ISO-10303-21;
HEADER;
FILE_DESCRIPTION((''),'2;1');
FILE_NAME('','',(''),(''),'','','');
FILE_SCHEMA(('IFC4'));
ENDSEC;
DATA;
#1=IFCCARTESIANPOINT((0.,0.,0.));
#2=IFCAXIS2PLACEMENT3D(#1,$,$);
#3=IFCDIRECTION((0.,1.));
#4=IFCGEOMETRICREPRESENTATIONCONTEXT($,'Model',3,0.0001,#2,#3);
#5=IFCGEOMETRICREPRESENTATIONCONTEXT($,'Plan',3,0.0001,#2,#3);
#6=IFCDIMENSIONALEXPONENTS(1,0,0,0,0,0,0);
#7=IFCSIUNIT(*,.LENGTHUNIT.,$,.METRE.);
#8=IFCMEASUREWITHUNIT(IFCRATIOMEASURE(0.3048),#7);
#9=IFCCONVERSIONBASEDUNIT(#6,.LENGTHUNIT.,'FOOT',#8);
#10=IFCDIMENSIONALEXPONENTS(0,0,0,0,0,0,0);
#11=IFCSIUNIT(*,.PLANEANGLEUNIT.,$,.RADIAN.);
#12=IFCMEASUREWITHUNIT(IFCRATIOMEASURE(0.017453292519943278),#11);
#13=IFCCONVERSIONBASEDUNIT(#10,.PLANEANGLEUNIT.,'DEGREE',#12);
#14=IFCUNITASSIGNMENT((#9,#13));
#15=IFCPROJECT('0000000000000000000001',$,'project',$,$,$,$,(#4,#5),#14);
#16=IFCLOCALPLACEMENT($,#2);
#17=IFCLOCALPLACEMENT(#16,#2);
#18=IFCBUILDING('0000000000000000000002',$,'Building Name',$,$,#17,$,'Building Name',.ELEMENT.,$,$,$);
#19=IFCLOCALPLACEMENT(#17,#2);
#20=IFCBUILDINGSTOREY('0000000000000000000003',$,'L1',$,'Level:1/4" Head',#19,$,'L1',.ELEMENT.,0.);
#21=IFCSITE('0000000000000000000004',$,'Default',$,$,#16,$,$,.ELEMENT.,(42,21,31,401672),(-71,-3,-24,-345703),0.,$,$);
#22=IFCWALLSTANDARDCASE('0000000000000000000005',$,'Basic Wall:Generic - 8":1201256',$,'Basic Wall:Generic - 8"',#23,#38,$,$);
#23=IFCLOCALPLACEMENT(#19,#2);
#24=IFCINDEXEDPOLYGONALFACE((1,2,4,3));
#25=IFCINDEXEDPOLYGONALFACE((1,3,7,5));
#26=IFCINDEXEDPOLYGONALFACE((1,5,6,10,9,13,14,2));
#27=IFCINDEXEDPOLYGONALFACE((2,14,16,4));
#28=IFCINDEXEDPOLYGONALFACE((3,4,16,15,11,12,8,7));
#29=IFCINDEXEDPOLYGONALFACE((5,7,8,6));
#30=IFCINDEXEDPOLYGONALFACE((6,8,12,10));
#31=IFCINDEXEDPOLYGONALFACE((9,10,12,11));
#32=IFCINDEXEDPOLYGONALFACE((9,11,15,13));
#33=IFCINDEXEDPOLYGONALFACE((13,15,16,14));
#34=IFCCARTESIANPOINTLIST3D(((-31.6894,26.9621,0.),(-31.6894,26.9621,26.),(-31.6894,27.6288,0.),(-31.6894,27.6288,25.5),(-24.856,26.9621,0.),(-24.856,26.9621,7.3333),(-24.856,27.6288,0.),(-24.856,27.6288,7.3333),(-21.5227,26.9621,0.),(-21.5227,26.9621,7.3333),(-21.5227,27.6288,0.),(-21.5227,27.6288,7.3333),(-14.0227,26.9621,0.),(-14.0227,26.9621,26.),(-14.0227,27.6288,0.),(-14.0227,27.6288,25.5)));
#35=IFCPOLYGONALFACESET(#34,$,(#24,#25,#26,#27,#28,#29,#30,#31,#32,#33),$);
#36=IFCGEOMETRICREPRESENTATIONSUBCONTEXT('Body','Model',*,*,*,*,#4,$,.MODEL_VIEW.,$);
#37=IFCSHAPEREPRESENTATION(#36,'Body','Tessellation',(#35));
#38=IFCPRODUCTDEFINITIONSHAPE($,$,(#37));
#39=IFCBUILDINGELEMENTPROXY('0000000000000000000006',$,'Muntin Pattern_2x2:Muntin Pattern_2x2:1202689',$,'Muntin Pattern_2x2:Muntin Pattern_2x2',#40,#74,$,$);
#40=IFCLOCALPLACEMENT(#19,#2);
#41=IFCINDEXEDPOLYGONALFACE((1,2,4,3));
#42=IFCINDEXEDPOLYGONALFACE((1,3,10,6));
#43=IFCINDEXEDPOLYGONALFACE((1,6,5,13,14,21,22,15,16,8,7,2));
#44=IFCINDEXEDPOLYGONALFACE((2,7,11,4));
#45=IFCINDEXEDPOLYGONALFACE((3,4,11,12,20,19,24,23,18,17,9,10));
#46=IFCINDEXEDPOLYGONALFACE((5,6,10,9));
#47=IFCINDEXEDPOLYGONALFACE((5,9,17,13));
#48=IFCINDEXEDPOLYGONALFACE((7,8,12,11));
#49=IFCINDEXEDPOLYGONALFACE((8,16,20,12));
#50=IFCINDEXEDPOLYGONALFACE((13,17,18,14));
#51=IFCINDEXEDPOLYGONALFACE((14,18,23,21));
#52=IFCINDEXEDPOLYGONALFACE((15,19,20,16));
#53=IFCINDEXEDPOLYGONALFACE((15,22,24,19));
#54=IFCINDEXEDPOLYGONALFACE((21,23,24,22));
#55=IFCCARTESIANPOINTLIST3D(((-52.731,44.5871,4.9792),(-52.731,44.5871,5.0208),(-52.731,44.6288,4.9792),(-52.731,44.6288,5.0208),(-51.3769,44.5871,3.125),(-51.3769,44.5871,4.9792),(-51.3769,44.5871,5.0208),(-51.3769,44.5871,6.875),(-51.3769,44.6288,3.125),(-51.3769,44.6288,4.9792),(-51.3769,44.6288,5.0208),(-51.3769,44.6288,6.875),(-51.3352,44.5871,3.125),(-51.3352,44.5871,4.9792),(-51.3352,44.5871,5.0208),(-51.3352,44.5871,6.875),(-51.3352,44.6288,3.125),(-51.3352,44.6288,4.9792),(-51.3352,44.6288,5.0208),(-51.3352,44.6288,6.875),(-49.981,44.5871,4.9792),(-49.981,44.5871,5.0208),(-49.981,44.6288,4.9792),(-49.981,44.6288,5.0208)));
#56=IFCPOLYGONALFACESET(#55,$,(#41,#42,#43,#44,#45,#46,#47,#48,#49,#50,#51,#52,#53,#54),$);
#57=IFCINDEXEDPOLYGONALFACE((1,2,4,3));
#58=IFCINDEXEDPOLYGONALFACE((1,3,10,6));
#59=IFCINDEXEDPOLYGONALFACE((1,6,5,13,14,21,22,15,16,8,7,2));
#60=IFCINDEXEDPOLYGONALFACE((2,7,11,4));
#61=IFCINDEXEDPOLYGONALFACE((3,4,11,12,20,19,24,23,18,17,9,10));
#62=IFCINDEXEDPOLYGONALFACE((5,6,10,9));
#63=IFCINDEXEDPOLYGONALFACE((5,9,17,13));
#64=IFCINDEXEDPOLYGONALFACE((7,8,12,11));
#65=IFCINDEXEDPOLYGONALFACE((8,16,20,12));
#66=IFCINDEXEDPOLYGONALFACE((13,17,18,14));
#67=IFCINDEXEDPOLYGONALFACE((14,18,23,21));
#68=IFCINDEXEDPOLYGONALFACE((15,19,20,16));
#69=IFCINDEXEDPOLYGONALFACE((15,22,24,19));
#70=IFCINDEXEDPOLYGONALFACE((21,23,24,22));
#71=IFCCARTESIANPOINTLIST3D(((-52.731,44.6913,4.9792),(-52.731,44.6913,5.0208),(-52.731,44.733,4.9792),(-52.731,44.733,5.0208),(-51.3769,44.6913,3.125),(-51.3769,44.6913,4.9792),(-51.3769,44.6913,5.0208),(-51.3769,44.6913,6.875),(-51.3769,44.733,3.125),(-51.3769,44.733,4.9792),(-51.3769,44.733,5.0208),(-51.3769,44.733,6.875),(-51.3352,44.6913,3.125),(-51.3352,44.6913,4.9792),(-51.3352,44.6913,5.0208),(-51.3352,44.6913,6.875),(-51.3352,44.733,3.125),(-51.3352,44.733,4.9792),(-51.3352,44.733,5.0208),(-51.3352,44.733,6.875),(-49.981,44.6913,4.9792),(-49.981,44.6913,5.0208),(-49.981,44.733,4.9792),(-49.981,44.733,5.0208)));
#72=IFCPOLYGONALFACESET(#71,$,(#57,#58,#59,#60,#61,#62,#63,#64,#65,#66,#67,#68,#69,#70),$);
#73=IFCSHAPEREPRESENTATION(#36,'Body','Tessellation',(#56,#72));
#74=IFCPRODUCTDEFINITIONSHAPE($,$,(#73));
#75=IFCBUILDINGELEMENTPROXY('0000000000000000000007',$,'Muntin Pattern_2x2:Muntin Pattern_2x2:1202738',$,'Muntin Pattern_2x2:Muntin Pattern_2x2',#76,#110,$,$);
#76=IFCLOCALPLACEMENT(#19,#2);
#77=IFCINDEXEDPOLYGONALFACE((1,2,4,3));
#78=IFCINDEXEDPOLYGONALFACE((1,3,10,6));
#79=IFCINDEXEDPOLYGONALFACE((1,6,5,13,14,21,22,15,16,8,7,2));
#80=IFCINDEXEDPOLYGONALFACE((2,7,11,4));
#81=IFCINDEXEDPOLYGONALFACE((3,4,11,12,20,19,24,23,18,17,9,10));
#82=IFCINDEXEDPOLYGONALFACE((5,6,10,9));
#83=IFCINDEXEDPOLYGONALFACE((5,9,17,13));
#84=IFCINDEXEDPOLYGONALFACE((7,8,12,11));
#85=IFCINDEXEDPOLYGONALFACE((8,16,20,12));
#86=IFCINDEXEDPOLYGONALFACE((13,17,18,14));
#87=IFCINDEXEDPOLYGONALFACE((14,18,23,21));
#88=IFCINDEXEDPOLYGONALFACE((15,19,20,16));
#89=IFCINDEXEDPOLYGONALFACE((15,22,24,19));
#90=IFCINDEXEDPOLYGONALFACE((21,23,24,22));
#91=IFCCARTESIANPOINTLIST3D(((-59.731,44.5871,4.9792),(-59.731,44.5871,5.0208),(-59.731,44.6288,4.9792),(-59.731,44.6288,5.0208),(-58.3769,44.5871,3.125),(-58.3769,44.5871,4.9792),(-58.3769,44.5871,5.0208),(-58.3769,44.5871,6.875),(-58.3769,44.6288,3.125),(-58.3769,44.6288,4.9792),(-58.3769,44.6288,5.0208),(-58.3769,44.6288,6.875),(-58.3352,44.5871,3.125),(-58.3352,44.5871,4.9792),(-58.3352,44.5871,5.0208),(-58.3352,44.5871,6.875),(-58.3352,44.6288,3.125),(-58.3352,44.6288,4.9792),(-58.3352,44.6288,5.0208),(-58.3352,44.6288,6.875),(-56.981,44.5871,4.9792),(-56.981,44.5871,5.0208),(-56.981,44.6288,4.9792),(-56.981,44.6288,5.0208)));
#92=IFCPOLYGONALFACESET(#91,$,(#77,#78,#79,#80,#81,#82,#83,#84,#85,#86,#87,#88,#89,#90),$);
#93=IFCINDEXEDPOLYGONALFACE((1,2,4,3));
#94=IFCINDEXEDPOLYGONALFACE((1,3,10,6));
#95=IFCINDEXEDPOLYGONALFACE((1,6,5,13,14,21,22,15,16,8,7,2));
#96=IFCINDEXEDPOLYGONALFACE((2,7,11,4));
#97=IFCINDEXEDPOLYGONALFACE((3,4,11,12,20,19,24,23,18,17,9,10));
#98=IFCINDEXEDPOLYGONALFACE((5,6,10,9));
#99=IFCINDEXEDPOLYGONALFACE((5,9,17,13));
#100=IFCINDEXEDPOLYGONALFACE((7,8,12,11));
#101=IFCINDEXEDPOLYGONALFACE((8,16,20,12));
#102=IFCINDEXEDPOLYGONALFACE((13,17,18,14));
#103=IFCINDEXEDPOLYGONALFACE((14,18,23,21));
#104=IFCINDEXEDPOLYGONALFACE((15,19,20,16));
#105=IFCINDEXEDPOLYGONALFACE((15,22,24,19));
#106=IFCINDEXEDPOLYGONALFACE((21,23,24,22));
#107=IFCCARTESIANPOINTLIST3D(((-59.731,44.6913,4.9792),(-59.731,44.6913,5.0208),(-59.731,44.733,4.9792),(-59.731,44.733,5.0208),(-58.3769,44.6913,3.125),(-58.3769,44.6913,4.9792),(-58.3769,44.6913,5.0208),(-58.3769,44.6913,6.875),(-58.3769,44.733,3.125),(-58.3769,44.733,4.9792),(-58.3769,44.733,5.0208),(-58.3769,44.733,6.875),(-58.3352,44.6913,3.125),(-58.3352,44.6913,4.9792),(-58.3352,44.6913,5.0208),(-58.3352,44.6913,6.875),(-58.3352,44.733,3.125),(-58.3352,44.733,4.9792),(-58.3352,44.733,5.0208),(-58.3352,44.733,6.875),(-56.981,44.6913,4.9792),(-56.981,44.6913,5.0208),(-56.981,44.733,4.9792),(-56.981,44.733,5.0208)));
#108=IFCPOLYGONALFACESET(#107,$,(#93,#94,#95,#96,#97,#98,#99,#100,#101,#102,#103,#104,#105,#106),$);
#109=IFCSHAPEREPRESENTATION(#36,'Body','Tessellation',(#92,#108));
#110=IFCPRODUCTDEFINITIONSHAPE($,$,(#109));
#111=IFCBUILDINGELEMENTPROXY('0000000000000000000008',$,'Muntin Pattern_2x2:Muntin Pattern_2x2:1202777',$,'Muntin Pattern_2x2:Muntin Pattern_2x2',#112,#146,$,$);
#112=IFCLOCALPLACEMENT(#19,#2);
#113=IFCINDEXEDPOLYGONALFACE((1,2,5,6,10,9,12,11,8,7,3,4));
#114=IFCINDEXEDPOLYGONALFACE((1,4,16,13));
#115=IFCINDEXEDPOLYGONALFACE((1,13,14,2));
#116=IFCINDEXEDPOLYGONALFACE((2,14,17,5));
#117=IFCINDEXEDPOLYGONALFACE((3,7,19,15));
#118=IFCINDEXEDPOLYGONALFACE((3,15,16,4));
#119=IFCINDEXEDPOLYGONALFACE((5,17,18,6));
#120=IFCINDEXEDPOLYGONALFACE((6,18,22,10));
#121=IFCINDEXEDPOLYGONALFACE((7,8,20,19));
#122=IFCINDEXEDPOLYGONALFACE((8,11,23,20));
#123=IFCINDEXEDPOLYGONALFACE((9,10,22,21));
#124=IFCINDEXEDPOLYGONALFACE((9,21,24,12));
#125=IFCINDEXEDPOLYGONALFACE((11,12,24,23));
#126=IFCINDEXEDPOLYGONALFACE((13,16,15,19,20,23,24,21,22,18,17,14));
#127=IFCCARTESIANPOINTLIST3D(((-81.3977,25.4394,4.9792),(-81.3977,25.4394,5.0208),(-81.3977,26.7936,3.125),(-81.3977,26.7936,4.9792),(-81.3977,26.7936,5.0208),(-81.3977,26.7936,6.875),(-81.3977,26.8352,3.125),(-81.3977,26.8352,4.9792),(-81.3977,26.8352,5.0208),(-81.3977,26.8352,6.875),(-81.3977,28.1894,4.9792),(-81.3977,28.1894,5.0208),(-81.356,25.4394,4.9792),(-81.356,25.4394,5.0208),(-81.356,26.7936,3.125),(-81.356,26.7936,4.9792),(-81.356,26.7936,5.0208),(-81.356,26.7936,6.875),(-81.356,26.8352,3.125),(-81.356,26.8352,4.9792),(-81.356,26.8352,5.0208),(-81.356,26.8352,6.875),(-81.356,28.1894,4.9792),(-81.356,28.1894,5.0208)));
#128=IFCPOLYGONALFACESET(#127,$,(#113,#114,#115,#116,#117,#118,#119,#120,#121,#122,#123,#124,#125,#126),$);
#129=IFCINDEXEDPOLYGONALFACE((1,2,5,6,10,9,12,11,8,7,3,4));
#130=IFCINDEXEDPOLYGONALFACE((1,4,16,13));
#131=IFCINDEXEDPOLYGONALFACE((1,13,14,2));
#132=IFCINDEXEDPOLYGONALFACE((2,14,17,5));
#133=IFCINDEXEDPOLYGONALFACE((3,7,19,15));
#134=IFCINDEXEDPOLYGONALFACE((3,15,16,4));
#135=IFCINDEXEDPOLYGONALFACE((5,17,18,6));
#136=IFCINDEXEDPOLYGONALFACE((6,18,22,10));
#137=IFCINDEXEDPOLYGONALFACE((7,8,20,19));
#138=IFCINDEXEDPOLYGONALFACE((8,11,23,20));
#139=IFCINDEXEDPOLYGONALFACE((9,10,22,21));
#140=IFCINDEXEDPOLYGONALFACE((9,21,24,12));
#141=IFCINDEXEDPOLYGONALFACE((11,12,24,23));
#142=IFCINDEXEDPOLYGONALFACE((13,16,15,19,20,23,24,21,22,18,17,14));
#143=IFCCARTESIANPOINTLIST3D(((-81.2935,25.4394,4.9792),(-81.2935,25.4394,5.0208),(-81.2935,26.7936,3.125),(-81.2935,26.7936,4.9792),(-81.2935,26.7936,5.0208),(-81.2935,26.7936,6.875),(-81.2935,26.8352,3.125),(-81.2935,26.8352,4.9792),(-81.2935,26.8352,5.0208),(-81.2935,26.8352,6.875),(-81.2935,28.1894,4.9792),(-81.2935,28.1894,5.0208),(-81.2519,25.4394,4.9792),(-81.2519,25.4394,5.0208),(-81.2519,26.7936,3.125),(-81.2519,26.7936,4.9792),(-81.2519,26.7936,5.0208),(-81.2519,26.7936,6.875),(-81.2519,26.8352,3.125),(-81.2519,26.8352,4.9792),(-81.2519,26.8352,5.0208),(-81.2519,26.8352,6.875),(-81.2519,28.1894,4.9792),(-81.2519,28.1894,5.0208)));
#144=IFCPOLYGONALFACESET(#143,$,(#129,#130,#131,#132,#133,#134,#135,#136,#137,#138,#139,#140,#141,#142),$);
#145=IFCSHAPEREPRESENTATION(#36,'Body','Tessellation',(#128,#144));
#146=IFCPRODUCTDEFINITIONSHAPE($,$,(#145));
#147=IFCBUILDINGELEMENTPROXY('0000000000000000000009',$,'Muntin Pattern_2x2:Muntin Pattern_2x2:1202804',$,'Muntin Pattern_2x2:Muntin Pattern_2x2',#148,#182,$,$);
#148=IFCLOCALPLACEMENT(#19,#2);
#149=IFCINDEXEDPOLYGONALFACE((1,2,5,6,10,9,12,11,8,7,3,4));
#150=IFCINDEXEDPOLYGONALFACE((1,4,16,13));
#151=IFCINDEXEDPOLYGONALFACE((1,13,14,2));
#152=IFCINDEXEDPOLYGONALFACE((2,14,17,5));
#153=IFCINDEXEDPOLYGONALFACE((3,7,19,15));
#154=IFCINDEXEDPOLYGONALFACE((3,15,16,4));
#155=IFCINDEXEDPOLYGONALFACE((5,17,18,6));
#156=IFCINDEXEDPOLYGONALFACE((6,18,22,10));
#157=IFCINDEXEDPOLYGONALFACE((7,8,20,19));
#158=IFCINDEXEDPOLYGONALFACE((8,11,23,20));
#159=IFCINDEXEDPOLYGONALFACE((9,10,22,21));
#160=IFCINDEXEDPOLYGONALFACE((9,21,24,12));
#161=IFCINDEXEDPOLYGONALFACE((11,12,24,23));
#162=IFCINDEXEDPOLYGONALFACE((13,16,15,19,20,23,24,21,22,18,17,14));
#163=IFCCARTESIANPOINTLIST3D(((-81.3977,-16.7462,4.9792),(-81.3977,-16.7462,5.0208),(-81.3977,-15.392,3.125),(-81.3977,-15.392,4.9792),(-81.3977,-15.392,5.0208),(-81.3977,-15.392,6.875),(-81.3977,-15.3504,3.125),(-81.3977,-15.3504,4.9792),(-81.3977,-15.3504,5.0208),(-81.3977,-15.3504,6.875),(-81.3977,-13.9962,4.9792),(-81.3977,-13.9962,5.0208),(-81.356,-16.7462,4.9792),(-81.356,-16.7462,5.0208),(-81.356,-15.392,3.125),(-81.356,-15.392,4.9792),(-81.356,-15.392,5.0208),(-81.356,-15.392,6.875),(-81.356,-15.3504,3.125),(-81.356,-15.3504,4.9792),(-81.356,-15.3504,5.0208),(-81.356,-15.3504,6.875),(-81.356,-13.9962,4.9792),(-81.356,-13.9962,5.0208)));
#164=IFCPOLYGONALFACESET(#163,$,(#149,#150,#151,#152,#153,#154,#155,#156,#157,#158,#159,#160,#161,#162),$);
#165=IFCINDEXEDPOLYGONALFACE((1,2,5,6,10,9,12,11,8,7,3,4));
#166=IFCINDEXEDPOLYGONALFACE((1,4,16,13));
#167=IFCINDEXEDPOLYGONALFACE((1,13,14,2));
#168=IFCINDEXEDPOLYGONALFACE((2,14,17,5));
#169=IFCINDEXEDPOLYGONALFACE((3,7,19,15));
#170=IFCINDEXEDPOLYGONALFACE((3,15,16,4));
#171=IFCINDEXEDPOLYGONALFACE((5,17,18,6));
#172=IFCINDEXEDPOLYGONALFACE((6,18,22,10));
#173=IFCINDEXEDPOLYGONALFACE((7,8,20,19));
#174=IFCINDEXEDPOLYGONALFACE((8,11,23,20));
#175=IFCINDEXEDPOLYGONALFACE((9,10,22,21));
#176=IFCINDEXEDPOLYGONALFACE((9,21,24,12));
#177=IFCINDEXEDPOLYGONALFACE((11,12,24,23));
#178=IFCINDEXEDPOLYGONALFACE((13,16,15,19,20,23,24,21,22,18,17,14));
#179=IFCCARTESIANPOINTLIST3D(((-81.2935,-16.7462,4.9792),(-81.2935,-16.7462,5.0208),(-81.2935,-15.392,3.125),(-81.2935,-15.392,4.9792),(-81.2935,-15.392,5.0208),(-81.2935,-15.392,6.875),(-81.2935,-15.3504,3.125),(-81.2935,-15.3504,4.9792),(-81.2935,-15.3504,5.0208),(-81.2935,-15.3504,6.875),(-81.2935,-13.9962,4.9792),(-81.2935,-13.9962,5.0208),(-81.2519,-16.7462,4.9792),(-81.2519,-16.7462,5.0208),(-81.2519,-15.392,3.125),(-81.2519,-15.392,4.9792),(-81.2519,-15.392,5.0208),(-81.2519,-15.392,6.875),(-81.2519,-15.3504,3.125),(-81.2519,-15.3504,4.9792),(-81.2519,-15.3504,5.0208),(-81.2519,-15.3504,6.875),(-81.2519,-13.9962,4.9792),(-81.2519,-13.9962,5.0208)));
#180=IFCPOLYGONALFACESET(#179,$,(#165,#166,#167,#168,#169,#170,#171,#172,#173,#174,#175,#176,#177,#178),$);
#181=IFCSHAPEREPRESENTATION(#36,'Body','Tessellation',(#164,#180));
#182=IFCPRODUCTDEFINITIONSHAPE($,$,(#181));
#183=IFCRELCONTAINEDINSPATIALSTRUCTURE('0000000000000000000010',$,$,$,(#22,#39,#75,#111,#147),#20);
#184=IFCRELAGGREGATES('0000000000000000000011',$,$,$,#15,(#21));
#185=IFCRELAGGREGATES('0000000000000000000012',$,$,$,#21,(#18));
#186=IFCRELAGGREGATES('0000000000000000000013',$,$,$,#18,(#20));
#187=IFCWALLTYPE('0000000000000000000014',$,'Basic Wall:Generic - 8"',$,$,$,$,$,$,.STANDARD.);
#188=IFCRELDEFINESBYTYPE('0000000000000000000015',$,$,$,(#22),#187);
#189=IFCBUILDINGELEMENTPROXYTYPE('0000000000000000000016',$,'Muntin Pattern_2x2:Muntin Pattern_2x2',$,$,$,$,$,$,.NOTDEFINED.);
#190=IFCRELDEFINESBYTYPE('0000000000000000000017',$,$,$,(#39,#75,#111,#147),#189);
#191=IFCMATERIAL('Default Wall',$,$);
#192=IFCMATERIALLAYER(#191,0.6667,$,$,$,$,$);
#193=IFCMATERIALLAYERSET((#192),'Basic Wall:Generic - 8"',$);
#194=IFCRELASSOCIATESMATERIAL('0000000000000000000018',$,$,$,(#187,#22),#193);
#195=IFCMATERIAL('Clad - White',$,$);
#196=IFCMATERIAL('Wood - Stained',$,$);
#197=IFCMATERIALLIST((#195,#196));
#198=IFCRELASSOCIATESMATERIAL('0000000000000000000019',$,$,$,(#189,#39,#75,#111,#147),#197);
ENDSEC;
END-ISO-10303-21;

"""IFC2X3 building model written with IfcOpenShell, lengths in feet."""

from ifc_helpers import new_model, entity, si_unit, converted_unit, direction, frame, frame_2d, origin, place, context, subcontext, project, spatial, polyline, rectangle, outline, extrude, clip, bounded_halfspace, source, transform, mapped, material, material_list, layer, layer_set, layer_usage, type_object, type_shapes, element, save


model = new_model("IFC2X3")

# Units and contexts
model_context = context("Model", 3, precision=0.0001, world=origin(), true_north=direction((0.0, 1.0)))
plan_context = context("Plan", 3, precision=0.0001, world=origin(), true_north=direction((0.0, 1.0)))
body_context = subcontext(model_context, "Body", "Model", "MODEL_VIEW")
ifc_project = project(units=[converted_unit("LENGTHUNIT", "FOOT", entity("IfcRatioMeasure", 0.3048), si_unit("LENGTHUNIT", "METRE"), dimensions=[1, 0, 0, 0, 0, 0, 0]), converted_unit("PLANEANGLEUNIT", "DEGREE", entity("IfcRatioMeasure", 0.017453292519943278), si_unit("PLANEANGLEUNIT", "RADIAN"), dimensions=[0, 0, 0, 0, 0, 0, 0])], contexts=[model_context, plan_context])

# Site, building, storey
site_placement = place(None, origin())
site = spatial("IfcSite", under=ifc_project, at=site_placement, Name="Default", CompositionType="ELEMENT", RefLatitude=(42, 21, 31, 401672), RefLongitude=(-71, -3, -24, -345703), RefElevation=0.0)
building_placement = place(site_placement, origin())
building = spatial("IfcBuilding", under=site, at=building_placement, Name="Building Name", LongName="Building Name", CompositionType="ELEMENT")
storey_placement = place(building_placement, origin())
storey = spatial("IfcBuildingStorey", under=building, at=storey_placement, Name="L1", ObjectType="Level:1/4\" Head", LongName="L1", CompositionType="ELEMENT", Elevation=0.0)

# Shared definitions
ifc_material_1 = material(Name="Default Wall")
ifc_layer_1 = layer(ifc_material_1, 0.6667)
ifc_layer_set_1 = layer_set([ifc_layer_1], Name="Basic Wall:Generic - 8\"")
ifc_layer_usage_1 = layer_usage(ifc_layer_set_1, "AXIS2", "NEGATIVE", 0.3333)
wall_type_1 = type_object("IfcWallType", Name="Basic Wall:Generic - 8\"", PredefinedType="STANDARD", material=ifc_layer_set_1)

# Wall, opening
wall_1_placement = place(storey_placement, frame((-31.6894, 27.2955, 0.0)))
wall_1 = element("IfcWallStandardCase", 1, at=wall_1_placement, inside=storey, type_object=wall_type_1, material=ifc_layer_usage_1, Name="Basic Wall:Generic - 8\":1201256", ObjectType="Basic Wall:Generic - 8\"", context=body_context, shape_type="Clipping", body=[
    clip(extrude(rectangle(XDim=17.6667, YDim=0.6667, at=frame_2d((8.8333, 0.0), x_axis=(1.0, 0.0))), origin(), (0.0, 0.0, 1.0), 26.0), bounded_halfspace(frame((0.0, -0.3333, 26.0), z_axis=(0.0, 0.6, 0.8), x_axis=(-1.0, 0.0, 0.0)), False, frame((0.0, -0.3333, 26.0)), polyline([(0.0, 0.0), (17.6667, 0.0), (17.6667, 0.6667), (17.0, 0.6667), (0.0, 0.6667), (0.0, 0.0)]))),
])
opening_1_placement = place(wall_1_placement, frame((6.8333, -0.3333, 0.0)))
element("IfcOpeningElement", 2, at=opening_1_placement, cuts=wall_1, ObjectType="Opening", context=body_context, shape_type="SweptSolid", body=[
    extrude(rectangle(XDim=7.3333, YDim=3.3333, at=frame_2d((3.6667, 1.6667), x_axis=(1.0, 0.0))), frame((0.0, 0.0, 0.0), z_axis=(0.0, 1.0, 0.0), x_axis=(0.0, 0.0, 1.0)), (0.0, 0.0, 1.0), 0.6667),
])

# Building element proxies
ifc_material_2 = material(Name="Clad - White")
ifc_material_3 = material(Name="Wood - Stained")
ifc_material_list = material_list([ifc_material_2, ifc_material_3])
building_element_proxy_type_1 = type_object("IfcBuildingElementProxyType", Name="Muntin Pattern_2x2:Muntin Pattern_2x2", PredefinedType="NOTDEFINED", material=ifc_material_list)
shared_shape_1 = source(origin(), body_context, "Body", "SweptSolid", [
    extrude(outline(polyline([(0.0208, -0.0208), (1.875, -0.0208), (1.875, 0.0208), (0.0208, 0.0208), (0.0208, 1.375), (-0.0208, 1.375), (-0.0208, 0.0208), (-1.875, 0.0208), (-1.875, -0.0208), (-0.0208, -0.0208), (-0.0208, -1.375), (0.0208, -1.375), (0.0208, -0.0208)])), frame((0.0, -0.0729, 1.875), z_axis=(0.0, 1.0, 0.0), x_axis=(0.0, 0.0, 1.0)), (0.0, 0.0, 1.0), 0.0417),
    extrude(outline(polyline([(0.0208, -0.0208), (1.875, -0.0208), (1.875, 0.0208), (0.0208, 0.0208), (0.0208, 1.375), (-0.0208, 1.375), (-0.0208, 0.0208), (-1.875, 0.0208), (-1.875, -0.0208), (-0.0208, -0.0208), (-0.0208, -1.375), (0.0208, -1.375), (0.0208, -0.0208)])), frame((0.0, 0.0313, 1.875), z_axis=(0.0, 1.0, 0.0), x_axis=(0.0, 0.0, 1.0)), (0.0, 0.0, 1.0), 0.0417),
])
type_shapes(building_element_proxy_type_1, [shared_shape_1])
for number, where, name in (
    (3, (-51.356, 44.66, 3.125), "Muntin Pattern_2x2:Muntin Pattern_2x2:1202689"),
    (4, (-58.356, 44.66, 3.125), "Muntin Pattern_2x2:Muntin Pattern_2x2:1202738"),
):
    element("IfcBuildingElementProxy", number, at=place(storey_placement, frame(where)), inside=storey, type_object=building_element_proxy_type_1, material=ifc_material_list, Name=name, ObjectType="Muntin Pattern_2x2:Muntin Pattern_2x2", context=body_context, shape_type="MappedRepresentation", body=[
        mapped(shared_shape_1, transform((0.0, 0.0, 0.0), scale=1.0)),
    ])
for number, where, z_axis, x_axis, name in (
    (5, (-81.3248, 26.8144, 3.125), (0.0, 0.0, 1.0), (0.0, -1.0, 0.0), "Muntin Pattern_2x2:Muntin Pattern_2x2:1202777"),
    (6, (-81.3248, -15.3712, 3.125), (0.0, 0.0, 1.0), (0.0, -1.0, 0.0), "Muntin Pattern_2x2:Muntin Pattern_2x2:1202804"),
):
    element("IfcBuildingElementProxy", number, at=place(storey_placement, frame(where, z_axis=z_axis, x_axis=x_axis)), inside=storey, type_object=building_element_proxy_type_1, material=ifc_material_list, Name=name, ObjectType="Muntin Pattern_2x2:Muntin Pattern_2x2", context=body_context, shape_type="MappedRepresentation", body=[
        mapped(shared_shape_1, transform((0.0, 0.0, 0.0), scale=1.0)),
    ])

save(model, "model.ifc")
